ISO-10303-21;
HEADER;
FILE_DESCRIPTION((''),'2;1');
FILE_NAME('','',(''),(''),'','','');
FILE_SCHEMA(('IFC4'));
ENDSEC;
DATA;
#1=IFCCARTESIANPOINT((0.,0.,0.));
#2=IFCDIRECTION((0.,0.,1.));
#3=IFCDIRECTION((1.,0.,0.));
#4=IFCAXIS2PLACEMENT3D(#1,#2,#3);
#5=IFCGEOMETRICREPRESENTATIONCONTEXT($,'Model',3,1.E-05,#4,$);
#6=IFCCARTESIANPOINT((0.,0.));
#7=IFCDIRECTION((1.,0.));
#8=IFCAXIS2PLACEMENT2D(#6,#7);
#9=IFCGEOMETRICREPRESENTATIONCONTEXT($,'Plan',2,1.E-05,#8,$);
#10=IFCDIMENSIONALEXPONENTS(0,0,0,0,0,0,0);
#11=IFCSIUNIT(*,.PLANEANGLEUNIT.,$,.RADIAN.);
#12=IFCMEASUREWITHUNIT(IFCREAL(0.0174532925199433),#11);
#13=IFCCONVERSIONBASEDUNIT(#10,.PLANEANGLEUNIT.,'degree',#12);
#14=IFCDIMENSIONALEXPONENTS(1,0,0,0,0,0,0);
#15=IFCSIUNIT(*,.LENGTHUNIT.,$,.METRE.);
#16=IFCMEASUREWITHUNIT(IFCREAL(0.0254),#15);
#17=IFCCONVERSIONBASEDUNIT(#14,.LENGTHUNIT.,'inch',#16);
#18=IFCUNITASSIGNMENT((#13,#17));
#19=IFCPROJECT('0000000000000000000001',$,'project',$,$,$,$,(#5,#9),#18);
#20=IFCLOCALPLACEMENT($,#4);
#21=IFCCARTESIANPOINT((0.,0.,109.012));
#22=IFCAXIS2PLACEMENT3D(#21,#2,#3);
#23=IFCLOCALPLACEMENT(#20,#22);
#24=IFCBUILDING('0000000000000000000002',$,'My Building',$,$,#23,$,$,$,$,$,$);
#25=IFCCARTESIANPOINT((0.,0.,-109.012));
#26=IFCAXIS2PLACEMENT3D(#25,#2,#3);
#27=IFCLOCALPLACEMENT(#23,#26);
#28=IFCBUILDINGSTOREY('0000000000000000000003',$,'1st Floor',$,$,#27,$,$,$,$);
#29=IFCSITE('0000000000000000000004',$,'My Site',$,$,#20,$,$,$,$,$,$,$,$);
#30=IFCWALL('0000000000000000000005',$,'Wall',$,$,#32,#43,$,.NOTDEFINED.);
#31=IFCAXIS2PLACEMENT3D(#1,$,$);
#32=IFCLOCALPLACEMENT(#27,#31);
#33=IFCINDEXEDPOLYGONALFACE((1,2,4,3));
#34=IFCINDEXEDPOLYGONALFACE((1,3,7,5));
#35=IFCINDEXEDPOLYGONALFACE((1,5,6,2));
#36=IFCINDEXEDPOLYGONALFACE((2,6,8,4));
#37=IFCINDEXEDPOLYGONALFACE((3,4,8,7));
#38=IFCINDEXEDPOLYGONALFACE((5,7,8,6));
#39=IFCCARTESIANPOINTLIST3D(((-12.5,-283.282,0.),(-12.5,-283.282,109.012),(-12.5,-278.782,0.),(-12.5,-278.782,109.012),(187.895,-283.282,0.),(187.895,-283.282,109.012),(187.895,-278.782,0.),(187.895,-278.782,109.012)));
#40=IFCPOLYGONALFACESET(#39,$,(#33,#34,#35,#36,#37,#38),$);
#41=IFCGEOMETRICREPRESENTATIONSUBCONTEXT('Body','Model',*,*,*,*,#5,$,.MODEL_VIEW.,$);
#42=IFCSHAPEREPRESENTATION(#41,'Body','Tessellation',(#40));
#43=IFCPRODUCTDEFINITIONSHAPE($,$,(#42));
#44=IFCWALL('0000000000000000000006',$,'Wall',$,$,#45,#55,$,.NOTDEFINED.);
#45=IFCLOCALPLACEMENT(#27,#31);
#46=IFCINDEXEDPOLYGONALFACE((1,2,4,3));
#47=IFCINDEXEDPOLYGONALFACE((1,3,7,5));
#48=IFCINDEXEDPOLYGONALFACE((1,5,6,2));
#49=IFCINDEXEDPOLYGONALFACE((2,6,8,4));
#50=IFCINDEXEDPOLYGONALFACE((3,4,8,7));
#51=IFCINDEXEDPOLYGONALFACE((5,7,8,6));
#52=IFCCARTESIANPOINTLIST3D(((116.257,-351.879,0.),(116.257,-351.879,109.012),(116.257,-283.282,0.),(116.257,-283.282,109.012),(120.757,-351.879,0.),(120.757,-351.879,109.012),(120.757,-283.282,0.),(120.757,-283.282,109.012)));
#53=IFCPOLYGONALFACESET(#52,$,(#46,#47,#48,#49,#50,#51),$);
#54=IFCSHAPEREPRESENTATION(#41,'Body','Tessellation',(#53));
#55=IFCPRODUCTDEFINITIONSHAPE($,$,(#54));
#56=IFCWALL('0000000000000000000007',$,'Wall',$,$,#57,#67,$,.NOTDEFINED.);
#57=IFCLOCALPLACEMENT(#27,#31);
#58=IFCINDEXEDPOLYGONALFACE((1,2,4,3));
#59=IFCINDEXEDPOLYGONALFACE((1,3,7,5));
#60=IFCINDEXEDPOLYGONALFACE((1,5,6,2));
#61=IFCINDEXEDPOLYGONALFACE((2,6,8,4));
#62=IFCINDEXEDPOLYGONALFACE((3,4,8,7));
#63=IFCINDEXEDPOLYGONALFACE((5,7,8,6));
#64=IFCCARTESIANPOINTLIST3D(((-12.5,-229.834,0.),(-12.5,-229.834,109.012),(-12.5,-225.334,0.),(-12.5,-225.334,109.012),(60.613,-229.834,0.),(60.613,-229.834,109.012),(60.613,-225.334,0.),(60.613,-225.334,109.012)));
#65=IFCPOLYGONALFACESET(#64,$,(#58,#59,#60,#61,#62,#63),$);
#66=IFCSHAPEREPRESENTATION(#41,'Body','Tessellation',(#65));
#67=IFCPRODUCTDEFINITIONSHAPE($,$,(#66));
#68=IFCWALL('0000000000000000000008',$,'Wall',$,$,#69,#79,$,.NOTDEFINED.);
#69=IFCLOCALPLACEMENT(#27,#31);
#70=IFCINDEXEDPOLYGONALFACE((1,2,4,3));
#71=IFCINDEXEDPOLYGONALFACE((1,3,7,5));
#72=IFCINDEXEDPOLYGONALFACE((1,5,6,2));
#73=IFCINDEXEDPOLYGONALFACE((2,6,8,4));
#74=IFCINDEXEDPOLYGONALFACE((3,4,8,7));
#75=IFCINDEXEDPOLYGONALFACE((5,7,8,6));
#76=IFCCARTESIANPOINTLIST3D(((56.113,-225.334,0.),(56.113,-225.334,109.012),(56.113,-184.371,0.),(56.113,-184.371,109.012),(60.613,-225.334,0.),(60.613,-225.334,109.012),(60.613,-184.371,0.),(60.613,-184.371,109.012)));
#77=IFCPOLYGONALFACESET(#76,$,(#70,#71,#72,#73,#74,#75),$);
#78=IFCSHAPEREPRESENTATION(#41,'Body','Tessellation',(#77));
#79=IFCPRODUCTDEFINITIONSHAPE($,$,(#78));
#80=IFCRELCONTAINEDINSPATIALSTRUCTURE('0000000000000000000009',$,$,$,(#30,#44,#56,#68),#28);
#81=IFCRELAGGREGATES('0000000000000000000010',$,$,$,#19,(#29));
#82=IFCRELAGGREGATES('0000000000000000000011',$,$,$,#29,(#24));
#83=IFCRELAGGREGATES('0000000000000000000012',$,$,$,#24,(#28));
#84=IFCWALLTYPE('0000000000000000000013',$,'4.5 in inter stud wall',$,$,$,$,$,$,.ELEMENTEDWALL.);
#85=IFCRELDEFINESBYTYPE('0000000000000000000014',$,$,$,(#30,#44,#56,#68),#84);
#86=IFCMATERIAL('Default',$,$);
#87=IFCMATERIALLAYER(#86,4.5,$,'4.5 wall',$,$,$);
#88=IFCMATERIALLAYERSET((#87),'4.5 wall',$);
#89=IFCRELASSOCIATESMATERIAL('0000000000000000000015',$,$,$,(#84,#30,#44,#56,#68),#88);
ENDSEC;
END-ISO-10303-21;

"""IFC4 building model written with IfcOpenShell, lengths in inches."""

from ifc_helpers import new_model, entity, si_unit, converted_unit, frame, origin_with_axes, origin_2d_with_axis, place, context, subcontext, project, spatial, indexed_curve, outline, extrude, material, layer, layer_set, layer_usage, type_object, element, save


model = new_model("IFC4")

# Units and contexts
model_context = context("Model", 3, precision=1e-05, world=origin_with_axes())
plan_context = context("Plan", 2, precision=1e-05, world=origin_2d_with_axis())
body_context = subcontext(model_context, "Body", "Model", "MODEL_VIEW")
ifc_project = project(units=[converted_unit("PLANEANGLEUNIT", "degree", entity("IfcReal", 0.0174532925199433), si_unit("PLANEANGLEUNIT", "RADIAN"), dimensions=[0, 0, 0, 0, 0, 0, 0]), converted_unit("LENGTHUNIT", "inch", entity("IfcReal", 0.0254), si_unit("LENGTHUNIT", "METRE"), dimensions=[1, 0, 0, 0, 0, 0, 0])], contexts=[model_context, plan_context])

# Site, building, storey
site_placement = place(None, origin_with_axes())
site = spatial("IfcSite", under=ifc_project, at=site_placement, Name="My Site")
building_placement = place(site_placement, frame((0.0, 0.0, 109.012), z_axis=(0.0, 0.0, 1.0), x_axis=(1.0, 0.0, 0.0)))
building = spatial("IfcBuilding", under=site, at=building_placement, Name="My Building")
storey_placement = place(building_placement, frame((0.0, 0.0, -109.012), z_axis=(0.0, 0.0, 1.0), x_axis=(1.0, 0.0, 0.0)))
storey = spatial("IfcBuildingStorey", under=building, at=storey_placement, Name="1st Floor")

# Shared definitions
ifc_material = material(Name="Default")

# Walls
ifc_layer_1 = layer(ifc_material, 4.5, Name="4.5 wall")
ifc_layer_set_1 = layer_set([ifc_layer_1], Name="4.5 wall")
wall_type_1 = type_object("IfcWallType", Name="4.5 in inter stud wall", PredefinedType="ELEMENTEDWALL", material=ifc_layer_set_1)
ifc_layer_usage_1 = layer_usage(ifc_layer_set_1, "AXIS2", "POSITIVE", 0.0)
wall_1_placement = place(storey_placement, frame((-12.5, -283.282, 0.0), z_axis=(0.0, 0.0, 1.0), x_axis=(1.0, 0.0, 0.0)))
element("IfcWall", 1, at=wall_1_placement, inside=storey, type_object=wall_type_1, material=ifc_layer_usage_1, Name="Wall", PredefinedType="NOTDEFINED", context=body_context, shape_type="SweptSolid", body=[
    extrude(outline(indexed_curve([(0.0, 0.0), (0.0, 4.5), (200.395, 4.5), (200.395, 0.0), (0.0, 0.0)], self_intersect=False)), origin_with_axes(), (0.0, 0.0, 1.0), 109.012),
])
ifc_layer_usage_2 = layer_usage(ifc_layer_set_1, "AXIS2", "POSITIVE", 0.0)
wall_2_placement = place(storey_placement, frame((116.257, -283.282, 0.0), z_axis=(0.0, 0.0, 1.0), x_axis=(0.0, -1.0, 0.0)))
element("IfcWall", 2, at=wall_2_placement, inside=storey, type_object=wall_type_1, material=ifc_layer_usage_2, Name="Wall", PredefinedType="NOTDEFINED", context=body_context, shape_type="SweptSolid", body=[
    extrude(outline(indexed_curve([(0.0, 0.0), (0.0, 4.5), (68.597, 4.5), (68.597, 0.0), (0.0, 0.0)], self_intersect=False)), origin_with_axes(), (0.0, 0.0, 1.0), 109.012),
])
ifc_layer_usage_3 = layer_usage(ifc_layer_set_1, "AXIS2", "POSITIVE", 0.0)
wall_3_placement = place(storey_placement, frame((-12.5, -229.834, 0.0), z_axis=(0.0, 0.0, 1.0), x_axis=(1.0, 0.0, 0.0)))
element("IfcWall", 3, at=wall_3_placement, inside=storey, type_object=wall_type_1, material=ifc_layer_usage_3, Name="Wall", PredefinedType="NOTDEFINED", context=body_context, shape_type="SweptSolid", body=[
    extrude(outline(indexed_curve([(0.0, 0.0), (0.0, 4.5), (73.113, 4.5), (73.113, 0.0), (0.0, 0.0)], self_intersect=False)), origin_with_axes(), (0.0, 0.0, 1.0), 109.012),
])
ifc_layer_usage_4 = layer_usage(ifc_layer_set_1, "AXIS2", "POSITIVE", 0.0)
wall_4_placement = place(storey_placement, frame((60.613, -225.334, 0.0), z_axis=(0.0, 0.0, 1.0), x_axis=(0.0, 1.0, 0.0)))
element("IfcWall", 4, at=wall_4_placement, inside=storey, type_object=wall_type_1, material=ifc_layer_usage_4, Name="Wall", PredefinedType="NOTDEFINED", context=body_context, shape_type="SweptSolid", body=[
    extrude(outline(indexed_curve([(0.0, 0.0), (0.0, 4.5), (40.963, 4.5), (40.963, 0.0), (0.0, 0.0)], self_intersect=False)), origin_with_axes(), (0.0, 0.0, 1.0), 109.012),
])

save(model, "model.ifc")
